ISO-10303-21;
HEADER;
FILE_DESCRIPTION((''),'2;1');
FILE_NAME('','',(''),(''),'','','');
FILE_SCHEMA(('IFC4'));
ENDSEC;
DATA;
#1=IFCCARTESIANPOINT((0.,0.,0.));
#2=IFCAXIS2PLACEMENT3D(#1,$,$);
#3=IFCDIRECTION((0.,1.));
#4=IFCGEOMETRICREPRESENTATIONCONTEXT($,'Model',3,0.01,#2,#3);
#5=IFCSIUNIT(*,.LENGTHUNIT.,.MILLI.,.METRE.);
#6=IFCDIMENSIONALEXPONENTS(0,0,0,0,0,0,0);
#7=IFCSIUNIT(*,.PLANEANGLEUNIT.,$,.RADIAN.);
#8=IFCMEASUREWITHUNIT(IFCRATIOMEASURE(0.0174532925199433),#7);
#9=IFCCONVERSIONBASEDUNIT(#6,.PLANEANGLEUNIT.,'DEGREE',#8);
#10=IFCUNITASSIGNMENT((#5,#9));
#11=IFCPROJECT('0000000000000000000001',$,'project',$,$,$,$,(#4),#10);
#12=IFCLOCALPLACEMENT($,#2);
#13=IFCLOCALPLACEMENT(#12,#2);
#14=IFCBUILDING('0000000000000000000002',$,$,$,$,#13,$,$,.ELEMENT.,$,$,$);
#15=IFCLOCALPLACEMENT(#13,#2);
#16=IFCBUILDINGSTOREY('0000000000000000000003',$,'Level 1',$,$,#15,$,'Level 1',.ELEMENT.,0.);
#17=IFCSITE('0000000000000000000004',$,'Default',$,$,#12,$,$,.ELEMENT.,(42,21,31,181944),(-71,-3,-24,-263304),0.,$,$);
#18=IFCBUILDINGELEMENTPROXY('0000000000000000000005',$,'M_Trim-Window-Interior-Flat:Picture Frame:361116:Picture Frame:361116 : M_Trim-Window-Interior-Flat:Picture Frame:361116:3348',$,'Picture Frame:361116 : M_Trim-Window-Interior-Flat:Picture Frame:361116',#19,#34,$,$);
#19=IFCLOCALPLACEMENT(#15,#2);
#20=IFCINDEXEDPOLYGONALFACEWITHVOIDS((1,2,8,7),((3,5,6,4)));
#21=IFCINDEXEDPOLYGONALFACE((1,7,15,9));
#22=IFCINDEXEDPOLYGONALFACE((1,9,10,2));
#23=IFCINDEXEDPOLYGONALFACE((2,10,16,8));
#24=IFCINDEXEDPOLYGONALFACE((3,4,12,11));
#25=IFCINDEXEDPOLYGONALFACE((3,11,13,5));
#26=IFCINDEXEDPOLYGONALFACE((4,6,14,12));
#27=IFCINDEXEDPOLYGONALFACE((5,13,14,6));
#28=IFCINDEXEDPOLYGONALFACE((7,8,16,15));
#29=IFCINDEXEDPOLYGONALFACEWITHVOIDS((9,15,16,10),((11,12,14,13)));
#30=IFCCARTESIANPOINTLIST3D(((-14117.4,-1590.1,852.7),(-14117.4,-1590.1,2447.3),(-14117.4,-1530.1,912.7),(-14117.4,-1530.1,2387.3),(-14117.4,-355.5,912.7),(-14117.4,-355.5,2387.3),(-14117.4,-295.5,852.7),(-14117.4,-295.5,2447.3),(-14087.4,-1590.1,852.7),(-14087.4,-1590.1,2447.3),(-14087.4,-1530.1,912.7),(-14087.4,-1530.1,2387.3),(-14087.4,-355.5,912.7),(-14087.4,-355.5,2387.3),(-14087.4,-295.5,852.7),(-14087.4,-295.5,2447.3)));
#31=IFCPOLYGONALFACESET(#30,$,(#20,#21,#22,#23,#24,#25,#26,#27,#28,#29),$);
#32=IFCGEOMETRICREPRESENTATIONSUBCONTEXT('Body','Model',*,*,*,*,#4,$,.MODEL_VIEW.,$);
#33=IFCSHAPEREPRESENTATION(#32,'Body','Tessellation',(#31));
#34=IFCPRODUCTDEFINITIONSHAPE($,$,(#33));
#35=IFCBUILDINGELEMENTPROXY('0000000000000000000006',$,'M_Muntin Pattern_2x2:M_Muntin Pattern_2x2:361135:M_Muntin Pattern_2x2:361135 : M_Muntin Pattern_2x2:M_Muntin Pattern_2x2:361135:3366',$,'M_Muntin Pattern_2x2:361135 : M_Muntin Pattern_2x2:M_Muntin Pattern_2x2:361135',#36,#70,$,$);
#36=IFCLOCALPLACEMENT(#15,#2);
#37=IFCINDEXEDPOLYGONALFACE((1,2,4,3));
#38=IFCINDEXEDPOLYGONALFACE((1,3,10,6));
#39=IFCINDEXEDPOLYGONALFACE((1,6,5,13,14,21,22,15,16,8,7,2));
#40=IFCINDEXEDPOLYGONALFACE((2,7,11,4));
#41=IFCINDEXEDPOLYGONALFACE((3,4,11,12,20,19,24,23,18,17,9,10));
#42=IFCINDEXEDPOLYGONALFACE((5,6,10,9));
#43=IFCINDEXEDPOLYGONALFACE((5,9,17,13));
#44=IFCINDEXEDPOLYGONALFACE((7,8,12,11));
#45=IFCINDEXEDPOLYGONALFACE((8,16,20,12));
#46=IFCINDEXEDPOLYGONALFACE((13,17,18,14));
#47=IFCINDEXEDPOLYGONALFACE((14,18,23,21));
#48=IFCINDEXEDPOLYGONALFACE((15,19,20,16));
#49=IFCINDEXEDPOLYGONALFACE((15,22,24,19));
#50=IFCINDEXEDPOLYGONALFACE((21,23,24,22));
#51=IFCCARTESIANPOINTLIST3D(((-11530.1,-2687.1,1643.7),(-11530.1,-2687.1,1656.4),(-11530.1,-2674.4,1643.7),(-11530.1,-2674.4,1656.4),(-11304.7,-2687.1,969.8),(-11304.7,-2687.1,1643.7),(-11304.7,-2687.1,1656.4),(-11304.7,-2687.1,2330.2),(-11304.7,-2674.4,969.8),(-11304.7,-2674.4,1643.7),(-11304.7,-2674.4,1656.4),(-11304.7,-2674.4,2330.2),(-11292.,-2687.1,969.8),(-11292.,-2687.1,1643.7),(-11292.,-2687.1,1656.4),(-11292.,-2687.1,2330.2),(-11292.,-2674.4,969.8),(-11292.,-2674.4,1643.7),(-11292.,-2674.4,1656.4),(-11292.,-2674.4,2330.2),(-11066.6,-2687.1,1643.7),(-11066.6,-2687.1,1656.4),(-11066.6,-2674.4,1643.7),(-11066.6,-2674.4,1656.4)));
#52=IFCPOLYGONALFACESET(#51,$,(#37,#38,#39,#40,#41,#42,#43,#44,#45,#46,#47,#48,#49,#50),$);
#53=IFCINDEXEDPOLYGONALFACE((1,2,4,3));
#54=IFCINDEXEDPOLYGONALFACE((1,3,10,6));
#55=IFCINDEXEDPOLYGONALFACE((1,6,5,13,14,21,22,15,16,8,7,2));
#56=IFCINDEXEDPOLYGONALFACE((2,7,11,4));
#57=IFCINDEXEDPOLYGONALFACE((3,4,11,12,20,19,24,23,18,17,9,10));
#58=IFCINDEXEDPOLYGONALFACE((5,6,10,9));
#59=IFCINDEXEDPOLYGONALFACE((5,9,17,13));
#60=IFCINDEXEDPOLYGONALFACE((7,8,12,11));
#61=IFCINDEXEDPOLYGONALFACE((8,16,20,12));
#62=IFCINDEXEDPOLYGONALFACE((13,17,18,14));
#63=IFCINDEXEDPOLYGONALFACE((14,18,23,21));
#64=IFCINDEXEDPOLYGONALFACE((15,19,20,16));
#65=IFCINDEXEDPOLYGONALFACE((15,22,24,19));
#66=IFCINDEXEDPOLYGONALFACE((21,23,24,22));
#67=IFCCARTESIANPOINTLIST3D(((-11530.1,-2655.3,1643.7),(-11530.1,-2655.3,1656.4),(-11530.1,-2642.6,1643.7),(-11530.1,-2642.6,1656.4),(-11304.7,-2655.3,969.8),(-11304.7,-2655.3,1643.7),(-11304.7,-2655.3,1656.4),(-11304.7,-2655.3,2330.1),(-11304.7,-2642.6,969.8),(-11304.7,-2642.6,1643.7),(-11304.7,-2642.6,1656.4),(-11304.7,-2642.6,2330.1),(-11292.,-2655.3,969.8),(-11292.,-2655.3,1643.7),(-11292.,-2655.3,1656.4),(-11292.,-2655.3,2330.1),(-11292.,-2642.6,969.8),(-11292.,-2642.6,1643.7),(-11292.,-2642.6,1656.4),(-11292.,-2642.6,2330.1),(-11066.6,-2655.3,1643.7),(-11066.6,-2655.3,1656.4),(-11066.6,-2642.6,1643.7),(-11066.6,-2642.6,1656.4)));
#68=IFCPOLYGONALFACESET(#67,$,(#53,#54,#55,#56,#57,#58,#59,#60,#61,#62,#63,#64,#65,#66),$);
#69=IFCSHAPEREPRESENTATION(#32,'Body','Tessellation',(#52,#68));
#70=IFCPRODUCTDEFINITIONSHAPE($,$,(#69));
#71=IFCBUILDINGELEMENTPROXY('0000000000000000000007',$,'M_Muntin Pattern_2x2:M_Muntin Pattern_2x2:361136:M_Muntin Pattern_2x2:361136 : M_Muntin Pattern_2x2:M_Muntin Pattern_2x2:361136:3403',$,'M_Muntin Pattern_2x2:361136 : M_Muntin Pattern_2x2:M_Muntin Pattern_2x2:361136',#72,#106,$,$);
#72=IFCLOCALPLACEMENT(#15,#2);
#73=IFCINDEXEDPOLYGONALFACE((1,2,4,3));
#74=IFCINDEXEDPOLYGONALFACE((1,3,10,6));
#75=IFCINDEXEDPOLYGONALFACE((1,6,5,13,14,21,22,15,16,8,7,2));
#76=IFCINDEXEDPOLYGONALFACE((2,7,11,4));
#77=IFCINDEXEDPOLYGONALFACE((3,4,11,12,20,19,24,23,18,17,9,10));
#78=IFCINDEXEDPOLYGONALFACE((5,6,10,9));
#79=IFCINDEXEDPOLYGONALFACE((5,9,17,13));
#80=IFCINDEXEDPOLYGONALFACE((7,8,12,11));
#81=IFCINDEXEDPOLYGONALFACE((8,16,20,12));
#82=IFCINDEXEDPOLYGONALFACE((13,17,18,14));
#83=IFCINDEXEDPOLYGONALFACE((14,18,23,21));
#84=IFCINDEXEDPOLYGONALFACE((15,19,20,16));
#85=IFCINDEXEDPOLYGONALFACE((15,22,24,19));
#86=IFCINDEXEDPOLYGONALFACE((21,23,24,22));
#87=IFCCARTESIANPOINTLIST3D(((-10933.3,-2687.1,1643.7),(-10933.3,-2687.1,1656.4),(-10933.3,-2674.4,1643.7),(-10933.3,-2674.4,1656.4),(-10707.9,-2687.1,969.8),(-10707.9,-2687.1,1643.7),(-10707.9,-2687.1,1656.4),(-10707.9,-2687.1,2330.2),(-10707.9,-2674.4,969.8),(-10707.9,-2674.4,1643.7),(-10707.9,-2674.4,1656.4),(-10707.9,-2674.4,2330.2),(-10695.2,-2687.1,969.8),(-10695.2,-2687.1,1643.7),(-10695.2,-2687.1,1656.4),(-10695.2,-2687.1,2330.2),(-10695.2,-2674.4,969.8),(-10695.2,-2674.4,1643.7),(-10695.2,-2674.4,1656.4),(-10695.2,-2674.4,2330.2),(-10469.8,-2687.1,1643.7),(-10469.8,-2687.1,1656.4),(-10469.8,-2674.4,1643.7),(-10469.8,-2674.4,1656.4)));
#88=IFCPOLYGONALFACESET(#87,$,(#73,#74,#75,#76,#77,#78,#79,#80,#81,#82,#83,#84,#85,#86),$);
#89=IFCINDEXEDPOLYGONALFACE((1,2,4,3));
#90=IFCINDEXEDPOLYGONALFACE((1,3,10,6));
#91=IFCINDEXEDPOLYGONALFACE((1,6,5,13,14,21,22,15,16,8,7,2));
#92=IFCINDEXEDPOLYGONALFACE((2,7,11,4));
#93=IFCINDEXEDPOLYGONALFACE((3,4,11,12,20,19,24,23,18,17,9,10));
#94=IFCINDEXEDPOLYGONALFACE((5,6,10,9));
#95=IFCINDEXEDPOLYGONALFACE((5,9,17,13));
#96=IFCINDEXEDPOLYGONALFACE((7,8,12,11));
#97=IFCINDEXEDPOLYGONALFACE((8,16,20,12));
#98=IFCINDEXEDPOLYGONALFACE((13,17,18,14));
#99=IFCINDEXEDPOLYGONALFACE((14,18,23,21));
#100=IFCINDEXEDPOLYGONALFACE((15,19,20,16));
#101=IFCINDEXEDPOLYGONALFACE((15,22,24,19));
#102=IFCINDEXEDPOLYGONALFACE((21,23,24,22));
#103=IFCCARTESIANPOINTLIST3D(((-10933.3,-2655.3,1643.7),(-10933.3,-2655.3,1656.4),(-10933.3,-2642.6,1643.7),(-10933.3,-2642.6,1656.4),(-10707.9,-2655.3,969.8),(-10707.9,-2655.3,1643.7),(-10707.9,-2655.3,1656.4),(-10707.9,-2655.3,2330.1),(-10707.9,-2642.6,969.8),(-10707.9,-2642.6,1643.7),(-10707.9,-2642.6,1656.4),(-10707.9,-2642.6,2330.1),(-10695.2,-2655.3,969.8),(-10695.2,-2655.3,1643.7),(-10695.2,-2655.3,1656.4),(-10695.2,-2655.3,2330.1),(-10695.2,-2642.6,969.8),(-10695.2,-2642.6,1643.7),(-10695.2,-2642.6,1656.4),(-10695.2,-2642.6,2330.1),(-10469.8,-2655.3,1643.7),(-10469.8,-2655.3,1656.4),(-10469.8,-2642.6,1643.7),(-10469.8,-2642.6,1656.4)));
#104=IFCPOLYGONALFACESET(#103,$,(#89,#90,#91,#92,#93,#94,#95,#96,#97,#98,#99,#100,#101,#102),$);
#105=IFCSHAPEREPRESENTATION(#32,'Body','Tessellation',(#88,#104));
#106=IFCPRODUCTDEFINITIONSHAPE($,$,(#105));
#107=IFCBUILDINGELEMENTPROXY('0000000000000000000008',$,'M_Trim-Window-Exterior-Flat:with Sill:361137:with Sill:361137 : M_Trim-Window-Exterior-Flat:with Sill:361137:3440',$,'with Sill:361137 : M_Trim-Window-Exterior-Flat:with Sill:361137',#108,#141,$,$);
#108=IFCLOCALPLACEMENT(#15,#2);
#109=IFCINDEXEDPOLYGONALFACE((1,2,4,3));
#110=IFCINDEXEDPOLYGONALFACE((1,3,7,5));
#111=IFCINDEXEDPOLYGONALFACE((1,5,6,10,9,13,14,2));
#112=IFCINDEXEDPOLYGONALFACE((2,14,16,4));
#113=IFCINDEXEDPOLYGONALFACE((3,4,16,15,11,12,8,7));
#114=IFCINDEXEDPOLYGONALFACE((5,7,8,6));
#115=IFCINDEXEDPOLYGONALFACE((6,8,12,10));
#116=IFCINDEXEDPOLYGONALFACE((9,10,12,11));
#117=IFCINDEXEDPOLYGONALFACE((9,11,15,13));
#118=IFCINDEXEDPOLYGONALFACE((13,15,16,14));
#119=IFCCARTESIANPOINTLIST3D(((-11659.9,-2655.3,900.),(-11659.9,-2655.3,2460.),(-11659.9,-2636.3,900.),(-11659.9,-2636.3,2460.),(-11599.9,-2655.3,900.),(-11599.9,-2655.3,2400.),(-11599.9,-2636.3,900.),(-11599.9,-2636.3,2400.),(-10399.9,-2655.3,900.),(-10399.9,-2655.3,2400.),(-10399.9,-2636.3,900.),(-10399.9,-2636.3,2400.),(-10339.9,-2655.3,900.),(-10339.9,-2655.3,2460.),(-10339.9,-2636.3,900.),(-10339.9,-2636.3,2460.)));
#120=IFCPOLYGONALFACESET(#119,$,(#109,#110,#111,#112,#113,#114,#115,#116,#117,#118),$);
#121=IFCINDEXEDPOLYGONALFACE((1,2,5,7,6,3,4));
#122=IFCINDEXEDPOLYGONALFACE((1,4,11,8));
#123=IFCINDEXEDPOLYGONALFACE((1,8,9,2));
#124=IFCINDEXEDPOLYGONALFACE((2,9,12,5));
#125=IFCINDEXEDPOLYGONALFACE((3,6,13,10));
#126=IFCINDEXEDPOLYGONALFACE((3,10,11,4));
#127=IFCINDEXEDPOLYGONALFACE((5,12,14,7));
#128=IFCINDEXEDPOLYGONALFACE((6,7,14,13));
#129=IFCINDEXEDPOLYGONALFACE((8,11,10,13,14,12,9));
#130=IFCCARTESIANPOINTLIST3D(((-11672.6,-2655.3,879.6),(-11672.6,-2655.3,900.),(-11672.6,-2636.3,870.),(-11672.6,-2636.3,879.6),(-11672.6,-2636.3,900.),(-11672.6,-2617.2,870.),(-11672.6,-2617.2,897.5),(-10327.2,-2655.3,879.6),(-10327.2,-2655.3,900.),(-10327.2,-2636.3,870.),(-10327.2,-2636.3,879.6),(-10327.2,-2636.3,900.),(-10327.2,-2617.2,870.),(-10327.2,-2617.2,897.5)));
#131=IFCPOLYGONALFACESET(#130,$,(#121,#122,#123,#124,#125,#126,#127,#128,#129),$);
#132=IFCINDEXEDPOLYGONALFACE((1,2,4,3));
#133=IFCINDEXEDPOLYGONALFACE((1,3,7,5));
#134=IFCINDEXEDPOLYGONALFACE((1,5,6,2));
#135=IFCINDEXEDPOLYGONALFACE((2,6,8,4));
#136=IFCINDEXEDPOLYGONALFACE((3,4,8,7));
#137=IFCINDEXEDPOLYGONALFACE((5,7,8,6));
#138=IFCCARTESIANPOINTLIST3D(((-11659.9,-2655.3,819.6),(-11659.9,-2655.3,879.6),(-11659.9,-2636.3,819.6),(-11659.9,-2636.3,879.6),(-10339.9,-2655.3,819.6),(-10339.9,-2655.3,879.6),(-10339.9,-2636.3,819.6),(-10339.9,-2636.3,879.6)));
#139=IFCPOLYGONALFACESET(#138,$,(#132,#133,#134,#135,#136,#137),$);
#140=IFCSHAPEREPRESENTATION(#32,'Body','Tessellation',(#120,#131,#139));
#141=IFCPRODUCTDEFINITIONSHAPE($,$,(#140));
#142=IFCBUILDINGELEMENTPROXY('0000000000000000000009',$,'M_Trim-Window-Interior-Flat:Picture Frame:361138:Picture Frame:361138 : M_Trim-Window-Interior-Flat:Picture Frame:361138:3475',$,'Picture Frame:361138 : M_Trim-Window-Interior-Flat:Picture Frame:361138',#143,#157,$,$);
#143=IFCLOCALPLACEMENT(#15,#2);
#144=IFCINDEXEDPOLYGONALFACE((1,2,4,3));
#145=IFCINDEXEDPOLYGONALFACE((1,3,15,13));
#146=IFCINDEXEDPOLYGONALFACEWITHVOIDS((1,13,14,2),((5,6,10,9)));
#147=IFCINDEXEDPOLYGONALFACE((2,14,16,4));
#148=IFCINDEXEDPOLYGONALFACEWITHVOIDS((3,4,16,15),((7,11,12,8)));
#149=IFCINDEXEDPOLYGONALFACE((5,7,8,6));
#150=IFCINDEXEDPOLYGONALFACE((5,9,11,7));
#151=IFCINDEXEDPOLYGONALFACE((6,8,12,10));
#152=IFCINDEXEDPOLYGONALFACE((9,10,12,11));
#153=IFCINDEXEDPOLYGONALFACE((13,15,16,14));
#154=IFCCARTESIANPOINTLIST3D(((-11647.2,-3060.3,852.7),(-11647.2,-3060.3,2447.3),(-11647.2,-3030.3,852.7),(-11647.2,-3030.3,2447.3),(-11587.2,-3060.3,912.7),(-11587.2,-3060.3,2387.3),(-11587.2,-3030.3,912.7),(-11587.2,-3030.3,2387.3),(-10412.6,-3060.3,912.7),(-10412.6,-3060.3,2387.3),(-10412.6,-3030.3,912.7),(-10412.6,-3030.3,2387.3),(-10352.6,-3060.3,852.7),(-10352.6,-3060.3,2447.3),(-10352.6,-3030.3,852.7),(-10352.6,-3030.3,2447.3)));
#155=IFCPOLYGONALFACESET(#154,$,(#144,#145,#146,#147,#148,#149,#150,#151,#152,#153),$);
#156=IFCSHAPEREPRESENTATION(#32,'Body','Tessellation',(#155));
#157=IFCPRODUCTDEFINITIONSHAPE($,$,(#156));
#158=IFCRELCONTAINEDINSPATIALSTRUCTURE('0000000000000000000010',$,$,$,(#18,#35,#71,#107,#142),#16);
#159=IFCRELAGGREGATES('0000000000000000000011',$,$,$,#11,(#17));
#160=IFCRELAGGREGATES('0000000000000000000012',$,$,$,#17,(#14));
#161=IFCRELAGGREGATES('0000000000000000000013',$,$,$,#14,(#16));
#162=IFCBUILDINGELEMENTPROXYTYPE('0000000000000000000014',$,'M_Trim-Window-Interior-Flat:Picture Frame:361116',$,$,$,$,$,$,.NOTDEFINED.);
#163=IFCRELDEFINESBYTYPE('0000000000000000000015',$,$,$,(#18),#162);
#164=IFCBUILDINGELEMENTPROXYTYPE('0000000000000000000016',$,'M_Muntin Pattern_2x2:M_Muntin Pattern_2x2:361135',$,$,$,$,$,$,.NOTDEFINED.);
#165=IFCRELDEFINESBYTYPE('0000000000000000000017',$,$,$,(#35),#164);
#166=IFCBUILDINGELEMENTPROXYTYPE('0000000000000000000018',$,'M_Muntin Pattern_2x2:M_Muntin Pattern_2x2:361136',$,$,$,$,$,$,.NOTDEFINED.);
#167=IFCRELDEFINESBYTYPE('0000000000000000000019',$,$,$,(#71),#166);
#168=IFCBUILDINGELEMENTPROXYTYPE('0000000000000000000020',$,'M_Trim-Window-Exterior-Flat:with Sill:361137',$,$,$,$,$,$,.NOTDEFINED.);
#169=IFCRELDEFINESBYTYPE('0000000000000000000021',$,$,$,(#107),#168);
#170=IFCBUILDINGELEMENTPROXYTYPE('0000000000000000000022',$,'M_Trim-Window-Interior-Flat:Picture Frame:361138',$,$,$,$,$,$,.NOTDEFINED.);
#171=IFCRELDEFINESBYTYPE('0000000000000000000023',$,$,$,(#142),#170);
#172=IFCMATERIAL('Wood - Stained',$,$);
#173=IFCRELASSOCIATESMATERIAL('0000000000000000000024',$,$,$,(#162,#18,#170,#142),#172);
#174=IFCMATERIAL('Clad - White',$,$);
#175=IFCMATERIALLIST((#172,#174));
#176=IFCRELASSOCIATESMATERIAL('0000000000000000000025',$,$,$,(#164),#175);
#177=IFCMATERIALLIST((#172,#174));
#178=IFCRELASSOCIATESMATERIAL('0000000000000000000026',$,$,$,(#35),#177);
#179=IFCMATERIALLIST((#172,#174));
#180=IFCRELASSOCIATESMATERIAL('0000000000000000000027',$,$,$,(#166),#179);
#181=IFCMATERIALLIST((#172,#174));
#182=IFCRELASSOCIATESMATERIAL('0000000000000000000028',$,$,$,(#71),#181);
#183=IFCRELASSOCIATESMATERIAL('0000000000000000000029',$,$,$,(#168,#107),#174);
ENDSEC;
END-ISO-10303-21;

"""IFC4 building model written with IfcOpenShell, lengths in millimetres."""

from ifc_helpers import new_model, entity, si_unit, converted_unit, direction, frame, origin, origin_2d_with_axis, place, context, subcontext, project, spatial, polyline, rectangle, outline, extrude, source, transform, mapped, material, material_list, type_object, type_shapes, element, save


model = new_model("IFC4")

# Units and contexts
model_context = context("Model", 3, precision=0.01, world=origin(), true_north=direction((0.0, 1.0)))
body_context = subcontext(model_context, "Body", "Model", "MODEL_VIEW")
ifc_project = project(units=[si_unit("LENGTHUNIT", "METRE", prefix="MILLI"), converted_unit("PLANEANGLEUNIT", "DEGREE", entity("IfcRatioMeasure", 0.0174532925199433), si_unit("PLANEANGLEUNIT", "RADIAN"), dimensions=[0, 0, 0, 0, 0, 0, 0])], contexts=[model_context])

# Site, building, storey
site_placement = place(None, origin())
site = spatial("IfcSite", under=ifc_project, at=site_placement, Name="Default", CompositionType="ELEMENT", RefLatitude=(42, 21, 31, 181944), RefLongitude=(-71, -3, -24, -263304), RefElevation=0.0)
building_placement = place(site_placement, origin())
building = spatial("IfcBuilding", under=site, at=building_placement, CompositionType="ELEMENT")
storey_placement = place(building_placement, origin())
storey = spatial("IfcBuildingStorey", under=building, at=storey_placement, Name="Level 1", LongName="Level 1", CompositionType="ELEMENT", Elevation=0.0)

# Building element proxies
ifc_material_1 = material(Name="Wood - Stained")
ifc_material_2 = material(Name="Clad - White")
building_element_proxy_type_1 = type_object("IfcBuildingElementProxyType", Name="M_Trim-Window-Interior-Flat:Picture Frame:361116", PredefinedType="NOTDEFINED", material=ifc_material_1)
shared_shape_1 = source(origin(), body_context, "Body", "SweptSolid", [
    extrude(outline(polyline([(-647.3, -797.3), (647.3, -797.3), (647.3, 797.3), (-647.3, 797.3), (-647.3, -797.3)]), holes=[polyline([(587.3, 737.3), (587.3, -737.3), (-587.3, -737.3), (-587.3, 737.3), (587.3, 737.3)])]), frame((-14117.4, -942.8, 1650.0), z_axis=(1.0, 0.0, 0.0), x_axis=(0.0, -1.0, 0.0)), (0.0, 0.0, 1.0), 30.0),
])
type_shapes(building_element_proxy_type_1, [shared_shape_1])
proxy_1_placement = place(storey_placement, origin())
element("IfcBuildingElementProxy", 1, at=proxy_1_placement, inside=storey, type_object=building_element_proxy_type_1, material=ifc_material_1, Name="M_Trim-Window-Interior-Flat:Picture Frame:361116:Picture Frame:361116 : M_Trim-Window-Interior-Flat:Picture Frame:361116:3348", ObjectType="Picture Frame:361116 : M_Trim-Window-Interior-Flat:Picture Frame:361116", context=body_context, shape_type="MappedRepresentation", body=[
    mapped(shared_shape_1, transform((0.0, 0.0, 0.0), scale=1.0)),
])
ifc_material_list_1 = material_list([ifc_material_1, ifc_material_2])
ifc_material_list_2 = material_list([ifc_material_1, ifc_material_2])
building_element_proxy_type_2 = type_object("IfcBuildingElementProxyType", Name="M_Muntin Pattern_2x2:M_Muntin Pattern_2x2:361135", PredefinedType="NOTDEFINED", material=ifc_material_list_2)
shared_shape_2 = source(origin(), body_context, "Body", "SweptSolid", [
    extrude(outline(polyline([(-6.4, -680.2), (6.3, -680.2), (6.3, -6.4), (231.7, -6.4), (231.7, 6.3), (6.3, 6.3), (6.3, 680.2), (-6.4, 680.2), (-6.4, 6.3), (-231.7, 6.3), (-231.7, -6.4), (-6.4, -6.4), (-6.4, -680.2)])), frame((-11298.4, -2687.1, 1650.0), z_axis=(0.0, 1.0, 0.0), x_axis=(1.0, 0.0, 0.0)), (0.0, 0.0, 1.0), 12.7),
    extrude(outline(polyline([(-6.4, -680.1), (6.3, -680.1), (6.3, -6.4), (231.7, -6.4), (231.7, 6.3), (6.3, 6.3), (6.3, 680.2), (-6.4, 680.2), (-6.4, 6.3), (-231.7, 6.3), (-231.7, -6.4), (-6.4, -6.4), (-6.4, -680.1)])), frame((-11298.4, -2655.3, 1650.0), z_axis=(0.0, 1.0, 0.0), x_axis=(1.0, 0.0, 0.0)), (0.0, 0.0, 1.0), 12.7),
])
type_shapes(building_element_proxy_type_2, [shared_shape_2])
proxy_2_placement = place(storey_placement, origin())
element("IfcBuildingElementProxy", 2, at=proxy_2_placement, inside=storey, type_object=building_element_proxy_type_2, material=ifc_material_list_1, Name="M_Muntin Pattern_2x2:M_Muntin Pattern_2x2:361135:M_Muntin Pattern_2x2:361135 : M_Muntin Pattern_2x2:M_Muntin Pattern_2x2:361135:3366", ObjectType="M_Muntin Pattern_2x2:361135 : M_Muntin Pattern_2x2:M_Muntin Pattern_2x2:361135", context=body_context, shape_type="MappedRepresentation", body=[
    mapped(shared_shape_2, transform((0.0, 0.0, 0.0), scale=1.0)),
])
ifc_material_list_3 = material_list([ifc_material_1, ifc_material_2])
ifc_material_list_4 = material_list([ifc_material_1, ifc_material_2])
building_element_proxy_type_3 = type_object("IfcBuildingElementProxyType", Name="M_Muntin Pattern_2x2:M_Muntin Pattern_2x2:361136", PredefinedType="NOTDEFINED", material=ifc_material_list_4)
shared_shape_3 = source(origin(), body_context, "Body", "SweptSolid", [
    extrude(outline(polyline([(-680.1, 6.4), (-680.1, -6.3), (-6.4, -6.3), (-6.4, -231.7), (6.3, -231.7), (6.3, -6.3), (680.2, -6.3), (680.2, 6.4), (6.3, 6.4), (6.3, 231.7), (-6.4, 231.7), (-6.4, 6.4), (-680.1, 6.4)])), frame((-10701.5, -2687.1, 1650.0), z_axis=(0.0, -1.0, 0.0), x_axis=(0.0, 0.0, -1.0)), (0.0, 0.0, -1.0), 12.7),
    extrude(outline(polyline([(-680.1, 6.4), (-680.1, -6.3), (-6.4, -6.3), (-6.4, -231.7), (6.3, -231.7), (6.3, -6.3), (680.2, -6.3), (680.2, 6.4), (6.3, 6.4), (6.3, 231.7), (-6.4, 231.7), (-6.4, 6.4), (-680.1, 6.4)])), frame((-10701.5, -2655.3, 1650.0), z_axis=(0.0, -1.0, 0.0), x_axis=(0.0, 0.0, -1.0)), (0.0, 0.0, -1.0), 12.7),
])
type_shapes(building_element_proxy_type_3, [shared_shape_3])
proxy_3_placement = place(storey_placement, origin())
element("IfcBuildingElementProxy", 3, at=proxy_3_placement, inside=storey, type_object=building_element_proxy_type_3, material=ifc_material_list_3, Name="M_Muntin Pattern_2x2:M_Muntin Pattern_2x2:361136:M_Muntin Pattern_2x2:361136 : M_Muntin Pattern_2x2:M_Muntin Pattern_2x2:361136:3403", ObjectType="M_Muntin Pattern_2x2:361136 : M_Muntin Pattern_2x2:M_Muntin Pattern_2x2:361136", context=body_context, shape_type="MappedRepresentation", body=[
    mapped(shared_shape_3, transform((0.0, 0.0, 0.0), scale=1.0)),
])
building_element_proxy_type_4 = type_object("IfcBuildingElementProxyType", Name="M_Trim-Window-Exterior-Flat:with Sill:361137", PredefinedType="NOTDEFINED", material=ifc_material_2)
shared_shape_4 = source(origin(), body_context, "Body", "SweptSolid", [
    extrude(outline(polyline([(-660.0, -765.0), (-600.0, -765.0), (-600.0, 735.0), (600.0, 735.0), (600.0, -765.0), (660.0, -765.0), (660.0, 795.0), (-660.0, 795.0), (-660.0, -765.0)])), frame((-10999.9, -2655.3, 1665.0), z_axis=(0.0, 1.0, 0.0), x_axis=(-1.0, 0.0, 0.0)), (0.0, 0.0, 1.0), 19.1),
    extrude(outline(polyline([(0.0, -15.2), (19.0, -15.2), (19.0, 12.3), (0.0, 14.8), (-19.0, 14.8), (-19.0, -5.7), (0.0, -5.7), (0.0, -15.2)])), frame((-11672.6, -2636.3, 885.2), z_axis=(1.0, 0.0, 0.0), x_axis=(0.0, 1.0, 0.0)), (0.0, 0.0, 1.0), 1345.4),
    extrude(rectangle(XDim=19.1, YDim=1320.0, at=origin_2d_with_axis()), frame((-10999.9, -2645.8, 819.6), z_axis=(0.0, 0.0, 1.0), x_axis=(0.0, -1.0, 0.0)), (0.0, 0.0, 1.0), 60.0),
])
type_shapes(building_element_proxy_type_4, [shared_shape_4])
proxy_4_placement = place(storey_placement, origin())
element("IfcBuildingElementProxy", 4, at=proxy_4_placement, inside=storey, type_object=building_element_proxy_type_4, material=ifc_material_2, Name="M_Trim-Window-Exterior-Flat:with Sill:361137:with Sill:361137 : M_Trim-Window-Exterior-Flat:with Sill:361137:3440", ObjectType="with Sill:361137 : M_Trim-Window-Exterior-Flat:with Sill:361137", context=body_context, shape_type="MappedRepresentation", body=[
    mapped(shared_shape_4, transform((0.0, 0.0, 0.0), scale=1.0)),
])
building_element_proxy_type_5 = type_object("IfcBuildingElementProxyType", Name="M_Trim-Window-Interior-Flat:Picture Frame:361138", PredefinedType="NOTDEFINED", material=ifc_material_1)
shared_shape_5 = source(origin(), body_context, "Body", "SweptSolid", [
    extrude(outline(polyline([(-647.3, -797.3), (647.3, -797.3), (647.3, 797.3), (-647.3, 797.3), (-647.3, -797.3)]), holes=[polyline([(587.3, 737.3), (587.3, -737.3), (-587.3, -737.3), (-587.3, 737.3), (587.3, 737.3)])]), frame((-10999.9, -3060.3, 1650.0), z_axis=(0.0, 1.0, 0.0), x_axis=(1.0, 0.0, 0.0)), (0.0, 0.0, 1.0), 30.0),
])
type_shapes(building_element_proxy_type_5, [shared_shape_5])
proxy_5_placement = place(storey_placement, origin())
element("IfcBuildingElementProxy", 5, at=proxy_5_placement, inside=storey, type_object=building_element_proxy_type_5, material=ifc_material_1, Name="M_Trim-Window-Interior-Flat:Picture Frame:361138:Picture Frame:361138 : M_Trim-Window-Interior-Flat:Picture Frame:361138:3475", ObjectType="Picture Frame:361138 : M_Trim-Window-Interior-Flat:Picture Frame:361138", context=body_context, shape_type="MappedRepresentation", body=[
    mapped(shared_shape_5, transform((0.0, 0.0, 0.0), scale=1.0)),
])

save(model, "model.ifc")
